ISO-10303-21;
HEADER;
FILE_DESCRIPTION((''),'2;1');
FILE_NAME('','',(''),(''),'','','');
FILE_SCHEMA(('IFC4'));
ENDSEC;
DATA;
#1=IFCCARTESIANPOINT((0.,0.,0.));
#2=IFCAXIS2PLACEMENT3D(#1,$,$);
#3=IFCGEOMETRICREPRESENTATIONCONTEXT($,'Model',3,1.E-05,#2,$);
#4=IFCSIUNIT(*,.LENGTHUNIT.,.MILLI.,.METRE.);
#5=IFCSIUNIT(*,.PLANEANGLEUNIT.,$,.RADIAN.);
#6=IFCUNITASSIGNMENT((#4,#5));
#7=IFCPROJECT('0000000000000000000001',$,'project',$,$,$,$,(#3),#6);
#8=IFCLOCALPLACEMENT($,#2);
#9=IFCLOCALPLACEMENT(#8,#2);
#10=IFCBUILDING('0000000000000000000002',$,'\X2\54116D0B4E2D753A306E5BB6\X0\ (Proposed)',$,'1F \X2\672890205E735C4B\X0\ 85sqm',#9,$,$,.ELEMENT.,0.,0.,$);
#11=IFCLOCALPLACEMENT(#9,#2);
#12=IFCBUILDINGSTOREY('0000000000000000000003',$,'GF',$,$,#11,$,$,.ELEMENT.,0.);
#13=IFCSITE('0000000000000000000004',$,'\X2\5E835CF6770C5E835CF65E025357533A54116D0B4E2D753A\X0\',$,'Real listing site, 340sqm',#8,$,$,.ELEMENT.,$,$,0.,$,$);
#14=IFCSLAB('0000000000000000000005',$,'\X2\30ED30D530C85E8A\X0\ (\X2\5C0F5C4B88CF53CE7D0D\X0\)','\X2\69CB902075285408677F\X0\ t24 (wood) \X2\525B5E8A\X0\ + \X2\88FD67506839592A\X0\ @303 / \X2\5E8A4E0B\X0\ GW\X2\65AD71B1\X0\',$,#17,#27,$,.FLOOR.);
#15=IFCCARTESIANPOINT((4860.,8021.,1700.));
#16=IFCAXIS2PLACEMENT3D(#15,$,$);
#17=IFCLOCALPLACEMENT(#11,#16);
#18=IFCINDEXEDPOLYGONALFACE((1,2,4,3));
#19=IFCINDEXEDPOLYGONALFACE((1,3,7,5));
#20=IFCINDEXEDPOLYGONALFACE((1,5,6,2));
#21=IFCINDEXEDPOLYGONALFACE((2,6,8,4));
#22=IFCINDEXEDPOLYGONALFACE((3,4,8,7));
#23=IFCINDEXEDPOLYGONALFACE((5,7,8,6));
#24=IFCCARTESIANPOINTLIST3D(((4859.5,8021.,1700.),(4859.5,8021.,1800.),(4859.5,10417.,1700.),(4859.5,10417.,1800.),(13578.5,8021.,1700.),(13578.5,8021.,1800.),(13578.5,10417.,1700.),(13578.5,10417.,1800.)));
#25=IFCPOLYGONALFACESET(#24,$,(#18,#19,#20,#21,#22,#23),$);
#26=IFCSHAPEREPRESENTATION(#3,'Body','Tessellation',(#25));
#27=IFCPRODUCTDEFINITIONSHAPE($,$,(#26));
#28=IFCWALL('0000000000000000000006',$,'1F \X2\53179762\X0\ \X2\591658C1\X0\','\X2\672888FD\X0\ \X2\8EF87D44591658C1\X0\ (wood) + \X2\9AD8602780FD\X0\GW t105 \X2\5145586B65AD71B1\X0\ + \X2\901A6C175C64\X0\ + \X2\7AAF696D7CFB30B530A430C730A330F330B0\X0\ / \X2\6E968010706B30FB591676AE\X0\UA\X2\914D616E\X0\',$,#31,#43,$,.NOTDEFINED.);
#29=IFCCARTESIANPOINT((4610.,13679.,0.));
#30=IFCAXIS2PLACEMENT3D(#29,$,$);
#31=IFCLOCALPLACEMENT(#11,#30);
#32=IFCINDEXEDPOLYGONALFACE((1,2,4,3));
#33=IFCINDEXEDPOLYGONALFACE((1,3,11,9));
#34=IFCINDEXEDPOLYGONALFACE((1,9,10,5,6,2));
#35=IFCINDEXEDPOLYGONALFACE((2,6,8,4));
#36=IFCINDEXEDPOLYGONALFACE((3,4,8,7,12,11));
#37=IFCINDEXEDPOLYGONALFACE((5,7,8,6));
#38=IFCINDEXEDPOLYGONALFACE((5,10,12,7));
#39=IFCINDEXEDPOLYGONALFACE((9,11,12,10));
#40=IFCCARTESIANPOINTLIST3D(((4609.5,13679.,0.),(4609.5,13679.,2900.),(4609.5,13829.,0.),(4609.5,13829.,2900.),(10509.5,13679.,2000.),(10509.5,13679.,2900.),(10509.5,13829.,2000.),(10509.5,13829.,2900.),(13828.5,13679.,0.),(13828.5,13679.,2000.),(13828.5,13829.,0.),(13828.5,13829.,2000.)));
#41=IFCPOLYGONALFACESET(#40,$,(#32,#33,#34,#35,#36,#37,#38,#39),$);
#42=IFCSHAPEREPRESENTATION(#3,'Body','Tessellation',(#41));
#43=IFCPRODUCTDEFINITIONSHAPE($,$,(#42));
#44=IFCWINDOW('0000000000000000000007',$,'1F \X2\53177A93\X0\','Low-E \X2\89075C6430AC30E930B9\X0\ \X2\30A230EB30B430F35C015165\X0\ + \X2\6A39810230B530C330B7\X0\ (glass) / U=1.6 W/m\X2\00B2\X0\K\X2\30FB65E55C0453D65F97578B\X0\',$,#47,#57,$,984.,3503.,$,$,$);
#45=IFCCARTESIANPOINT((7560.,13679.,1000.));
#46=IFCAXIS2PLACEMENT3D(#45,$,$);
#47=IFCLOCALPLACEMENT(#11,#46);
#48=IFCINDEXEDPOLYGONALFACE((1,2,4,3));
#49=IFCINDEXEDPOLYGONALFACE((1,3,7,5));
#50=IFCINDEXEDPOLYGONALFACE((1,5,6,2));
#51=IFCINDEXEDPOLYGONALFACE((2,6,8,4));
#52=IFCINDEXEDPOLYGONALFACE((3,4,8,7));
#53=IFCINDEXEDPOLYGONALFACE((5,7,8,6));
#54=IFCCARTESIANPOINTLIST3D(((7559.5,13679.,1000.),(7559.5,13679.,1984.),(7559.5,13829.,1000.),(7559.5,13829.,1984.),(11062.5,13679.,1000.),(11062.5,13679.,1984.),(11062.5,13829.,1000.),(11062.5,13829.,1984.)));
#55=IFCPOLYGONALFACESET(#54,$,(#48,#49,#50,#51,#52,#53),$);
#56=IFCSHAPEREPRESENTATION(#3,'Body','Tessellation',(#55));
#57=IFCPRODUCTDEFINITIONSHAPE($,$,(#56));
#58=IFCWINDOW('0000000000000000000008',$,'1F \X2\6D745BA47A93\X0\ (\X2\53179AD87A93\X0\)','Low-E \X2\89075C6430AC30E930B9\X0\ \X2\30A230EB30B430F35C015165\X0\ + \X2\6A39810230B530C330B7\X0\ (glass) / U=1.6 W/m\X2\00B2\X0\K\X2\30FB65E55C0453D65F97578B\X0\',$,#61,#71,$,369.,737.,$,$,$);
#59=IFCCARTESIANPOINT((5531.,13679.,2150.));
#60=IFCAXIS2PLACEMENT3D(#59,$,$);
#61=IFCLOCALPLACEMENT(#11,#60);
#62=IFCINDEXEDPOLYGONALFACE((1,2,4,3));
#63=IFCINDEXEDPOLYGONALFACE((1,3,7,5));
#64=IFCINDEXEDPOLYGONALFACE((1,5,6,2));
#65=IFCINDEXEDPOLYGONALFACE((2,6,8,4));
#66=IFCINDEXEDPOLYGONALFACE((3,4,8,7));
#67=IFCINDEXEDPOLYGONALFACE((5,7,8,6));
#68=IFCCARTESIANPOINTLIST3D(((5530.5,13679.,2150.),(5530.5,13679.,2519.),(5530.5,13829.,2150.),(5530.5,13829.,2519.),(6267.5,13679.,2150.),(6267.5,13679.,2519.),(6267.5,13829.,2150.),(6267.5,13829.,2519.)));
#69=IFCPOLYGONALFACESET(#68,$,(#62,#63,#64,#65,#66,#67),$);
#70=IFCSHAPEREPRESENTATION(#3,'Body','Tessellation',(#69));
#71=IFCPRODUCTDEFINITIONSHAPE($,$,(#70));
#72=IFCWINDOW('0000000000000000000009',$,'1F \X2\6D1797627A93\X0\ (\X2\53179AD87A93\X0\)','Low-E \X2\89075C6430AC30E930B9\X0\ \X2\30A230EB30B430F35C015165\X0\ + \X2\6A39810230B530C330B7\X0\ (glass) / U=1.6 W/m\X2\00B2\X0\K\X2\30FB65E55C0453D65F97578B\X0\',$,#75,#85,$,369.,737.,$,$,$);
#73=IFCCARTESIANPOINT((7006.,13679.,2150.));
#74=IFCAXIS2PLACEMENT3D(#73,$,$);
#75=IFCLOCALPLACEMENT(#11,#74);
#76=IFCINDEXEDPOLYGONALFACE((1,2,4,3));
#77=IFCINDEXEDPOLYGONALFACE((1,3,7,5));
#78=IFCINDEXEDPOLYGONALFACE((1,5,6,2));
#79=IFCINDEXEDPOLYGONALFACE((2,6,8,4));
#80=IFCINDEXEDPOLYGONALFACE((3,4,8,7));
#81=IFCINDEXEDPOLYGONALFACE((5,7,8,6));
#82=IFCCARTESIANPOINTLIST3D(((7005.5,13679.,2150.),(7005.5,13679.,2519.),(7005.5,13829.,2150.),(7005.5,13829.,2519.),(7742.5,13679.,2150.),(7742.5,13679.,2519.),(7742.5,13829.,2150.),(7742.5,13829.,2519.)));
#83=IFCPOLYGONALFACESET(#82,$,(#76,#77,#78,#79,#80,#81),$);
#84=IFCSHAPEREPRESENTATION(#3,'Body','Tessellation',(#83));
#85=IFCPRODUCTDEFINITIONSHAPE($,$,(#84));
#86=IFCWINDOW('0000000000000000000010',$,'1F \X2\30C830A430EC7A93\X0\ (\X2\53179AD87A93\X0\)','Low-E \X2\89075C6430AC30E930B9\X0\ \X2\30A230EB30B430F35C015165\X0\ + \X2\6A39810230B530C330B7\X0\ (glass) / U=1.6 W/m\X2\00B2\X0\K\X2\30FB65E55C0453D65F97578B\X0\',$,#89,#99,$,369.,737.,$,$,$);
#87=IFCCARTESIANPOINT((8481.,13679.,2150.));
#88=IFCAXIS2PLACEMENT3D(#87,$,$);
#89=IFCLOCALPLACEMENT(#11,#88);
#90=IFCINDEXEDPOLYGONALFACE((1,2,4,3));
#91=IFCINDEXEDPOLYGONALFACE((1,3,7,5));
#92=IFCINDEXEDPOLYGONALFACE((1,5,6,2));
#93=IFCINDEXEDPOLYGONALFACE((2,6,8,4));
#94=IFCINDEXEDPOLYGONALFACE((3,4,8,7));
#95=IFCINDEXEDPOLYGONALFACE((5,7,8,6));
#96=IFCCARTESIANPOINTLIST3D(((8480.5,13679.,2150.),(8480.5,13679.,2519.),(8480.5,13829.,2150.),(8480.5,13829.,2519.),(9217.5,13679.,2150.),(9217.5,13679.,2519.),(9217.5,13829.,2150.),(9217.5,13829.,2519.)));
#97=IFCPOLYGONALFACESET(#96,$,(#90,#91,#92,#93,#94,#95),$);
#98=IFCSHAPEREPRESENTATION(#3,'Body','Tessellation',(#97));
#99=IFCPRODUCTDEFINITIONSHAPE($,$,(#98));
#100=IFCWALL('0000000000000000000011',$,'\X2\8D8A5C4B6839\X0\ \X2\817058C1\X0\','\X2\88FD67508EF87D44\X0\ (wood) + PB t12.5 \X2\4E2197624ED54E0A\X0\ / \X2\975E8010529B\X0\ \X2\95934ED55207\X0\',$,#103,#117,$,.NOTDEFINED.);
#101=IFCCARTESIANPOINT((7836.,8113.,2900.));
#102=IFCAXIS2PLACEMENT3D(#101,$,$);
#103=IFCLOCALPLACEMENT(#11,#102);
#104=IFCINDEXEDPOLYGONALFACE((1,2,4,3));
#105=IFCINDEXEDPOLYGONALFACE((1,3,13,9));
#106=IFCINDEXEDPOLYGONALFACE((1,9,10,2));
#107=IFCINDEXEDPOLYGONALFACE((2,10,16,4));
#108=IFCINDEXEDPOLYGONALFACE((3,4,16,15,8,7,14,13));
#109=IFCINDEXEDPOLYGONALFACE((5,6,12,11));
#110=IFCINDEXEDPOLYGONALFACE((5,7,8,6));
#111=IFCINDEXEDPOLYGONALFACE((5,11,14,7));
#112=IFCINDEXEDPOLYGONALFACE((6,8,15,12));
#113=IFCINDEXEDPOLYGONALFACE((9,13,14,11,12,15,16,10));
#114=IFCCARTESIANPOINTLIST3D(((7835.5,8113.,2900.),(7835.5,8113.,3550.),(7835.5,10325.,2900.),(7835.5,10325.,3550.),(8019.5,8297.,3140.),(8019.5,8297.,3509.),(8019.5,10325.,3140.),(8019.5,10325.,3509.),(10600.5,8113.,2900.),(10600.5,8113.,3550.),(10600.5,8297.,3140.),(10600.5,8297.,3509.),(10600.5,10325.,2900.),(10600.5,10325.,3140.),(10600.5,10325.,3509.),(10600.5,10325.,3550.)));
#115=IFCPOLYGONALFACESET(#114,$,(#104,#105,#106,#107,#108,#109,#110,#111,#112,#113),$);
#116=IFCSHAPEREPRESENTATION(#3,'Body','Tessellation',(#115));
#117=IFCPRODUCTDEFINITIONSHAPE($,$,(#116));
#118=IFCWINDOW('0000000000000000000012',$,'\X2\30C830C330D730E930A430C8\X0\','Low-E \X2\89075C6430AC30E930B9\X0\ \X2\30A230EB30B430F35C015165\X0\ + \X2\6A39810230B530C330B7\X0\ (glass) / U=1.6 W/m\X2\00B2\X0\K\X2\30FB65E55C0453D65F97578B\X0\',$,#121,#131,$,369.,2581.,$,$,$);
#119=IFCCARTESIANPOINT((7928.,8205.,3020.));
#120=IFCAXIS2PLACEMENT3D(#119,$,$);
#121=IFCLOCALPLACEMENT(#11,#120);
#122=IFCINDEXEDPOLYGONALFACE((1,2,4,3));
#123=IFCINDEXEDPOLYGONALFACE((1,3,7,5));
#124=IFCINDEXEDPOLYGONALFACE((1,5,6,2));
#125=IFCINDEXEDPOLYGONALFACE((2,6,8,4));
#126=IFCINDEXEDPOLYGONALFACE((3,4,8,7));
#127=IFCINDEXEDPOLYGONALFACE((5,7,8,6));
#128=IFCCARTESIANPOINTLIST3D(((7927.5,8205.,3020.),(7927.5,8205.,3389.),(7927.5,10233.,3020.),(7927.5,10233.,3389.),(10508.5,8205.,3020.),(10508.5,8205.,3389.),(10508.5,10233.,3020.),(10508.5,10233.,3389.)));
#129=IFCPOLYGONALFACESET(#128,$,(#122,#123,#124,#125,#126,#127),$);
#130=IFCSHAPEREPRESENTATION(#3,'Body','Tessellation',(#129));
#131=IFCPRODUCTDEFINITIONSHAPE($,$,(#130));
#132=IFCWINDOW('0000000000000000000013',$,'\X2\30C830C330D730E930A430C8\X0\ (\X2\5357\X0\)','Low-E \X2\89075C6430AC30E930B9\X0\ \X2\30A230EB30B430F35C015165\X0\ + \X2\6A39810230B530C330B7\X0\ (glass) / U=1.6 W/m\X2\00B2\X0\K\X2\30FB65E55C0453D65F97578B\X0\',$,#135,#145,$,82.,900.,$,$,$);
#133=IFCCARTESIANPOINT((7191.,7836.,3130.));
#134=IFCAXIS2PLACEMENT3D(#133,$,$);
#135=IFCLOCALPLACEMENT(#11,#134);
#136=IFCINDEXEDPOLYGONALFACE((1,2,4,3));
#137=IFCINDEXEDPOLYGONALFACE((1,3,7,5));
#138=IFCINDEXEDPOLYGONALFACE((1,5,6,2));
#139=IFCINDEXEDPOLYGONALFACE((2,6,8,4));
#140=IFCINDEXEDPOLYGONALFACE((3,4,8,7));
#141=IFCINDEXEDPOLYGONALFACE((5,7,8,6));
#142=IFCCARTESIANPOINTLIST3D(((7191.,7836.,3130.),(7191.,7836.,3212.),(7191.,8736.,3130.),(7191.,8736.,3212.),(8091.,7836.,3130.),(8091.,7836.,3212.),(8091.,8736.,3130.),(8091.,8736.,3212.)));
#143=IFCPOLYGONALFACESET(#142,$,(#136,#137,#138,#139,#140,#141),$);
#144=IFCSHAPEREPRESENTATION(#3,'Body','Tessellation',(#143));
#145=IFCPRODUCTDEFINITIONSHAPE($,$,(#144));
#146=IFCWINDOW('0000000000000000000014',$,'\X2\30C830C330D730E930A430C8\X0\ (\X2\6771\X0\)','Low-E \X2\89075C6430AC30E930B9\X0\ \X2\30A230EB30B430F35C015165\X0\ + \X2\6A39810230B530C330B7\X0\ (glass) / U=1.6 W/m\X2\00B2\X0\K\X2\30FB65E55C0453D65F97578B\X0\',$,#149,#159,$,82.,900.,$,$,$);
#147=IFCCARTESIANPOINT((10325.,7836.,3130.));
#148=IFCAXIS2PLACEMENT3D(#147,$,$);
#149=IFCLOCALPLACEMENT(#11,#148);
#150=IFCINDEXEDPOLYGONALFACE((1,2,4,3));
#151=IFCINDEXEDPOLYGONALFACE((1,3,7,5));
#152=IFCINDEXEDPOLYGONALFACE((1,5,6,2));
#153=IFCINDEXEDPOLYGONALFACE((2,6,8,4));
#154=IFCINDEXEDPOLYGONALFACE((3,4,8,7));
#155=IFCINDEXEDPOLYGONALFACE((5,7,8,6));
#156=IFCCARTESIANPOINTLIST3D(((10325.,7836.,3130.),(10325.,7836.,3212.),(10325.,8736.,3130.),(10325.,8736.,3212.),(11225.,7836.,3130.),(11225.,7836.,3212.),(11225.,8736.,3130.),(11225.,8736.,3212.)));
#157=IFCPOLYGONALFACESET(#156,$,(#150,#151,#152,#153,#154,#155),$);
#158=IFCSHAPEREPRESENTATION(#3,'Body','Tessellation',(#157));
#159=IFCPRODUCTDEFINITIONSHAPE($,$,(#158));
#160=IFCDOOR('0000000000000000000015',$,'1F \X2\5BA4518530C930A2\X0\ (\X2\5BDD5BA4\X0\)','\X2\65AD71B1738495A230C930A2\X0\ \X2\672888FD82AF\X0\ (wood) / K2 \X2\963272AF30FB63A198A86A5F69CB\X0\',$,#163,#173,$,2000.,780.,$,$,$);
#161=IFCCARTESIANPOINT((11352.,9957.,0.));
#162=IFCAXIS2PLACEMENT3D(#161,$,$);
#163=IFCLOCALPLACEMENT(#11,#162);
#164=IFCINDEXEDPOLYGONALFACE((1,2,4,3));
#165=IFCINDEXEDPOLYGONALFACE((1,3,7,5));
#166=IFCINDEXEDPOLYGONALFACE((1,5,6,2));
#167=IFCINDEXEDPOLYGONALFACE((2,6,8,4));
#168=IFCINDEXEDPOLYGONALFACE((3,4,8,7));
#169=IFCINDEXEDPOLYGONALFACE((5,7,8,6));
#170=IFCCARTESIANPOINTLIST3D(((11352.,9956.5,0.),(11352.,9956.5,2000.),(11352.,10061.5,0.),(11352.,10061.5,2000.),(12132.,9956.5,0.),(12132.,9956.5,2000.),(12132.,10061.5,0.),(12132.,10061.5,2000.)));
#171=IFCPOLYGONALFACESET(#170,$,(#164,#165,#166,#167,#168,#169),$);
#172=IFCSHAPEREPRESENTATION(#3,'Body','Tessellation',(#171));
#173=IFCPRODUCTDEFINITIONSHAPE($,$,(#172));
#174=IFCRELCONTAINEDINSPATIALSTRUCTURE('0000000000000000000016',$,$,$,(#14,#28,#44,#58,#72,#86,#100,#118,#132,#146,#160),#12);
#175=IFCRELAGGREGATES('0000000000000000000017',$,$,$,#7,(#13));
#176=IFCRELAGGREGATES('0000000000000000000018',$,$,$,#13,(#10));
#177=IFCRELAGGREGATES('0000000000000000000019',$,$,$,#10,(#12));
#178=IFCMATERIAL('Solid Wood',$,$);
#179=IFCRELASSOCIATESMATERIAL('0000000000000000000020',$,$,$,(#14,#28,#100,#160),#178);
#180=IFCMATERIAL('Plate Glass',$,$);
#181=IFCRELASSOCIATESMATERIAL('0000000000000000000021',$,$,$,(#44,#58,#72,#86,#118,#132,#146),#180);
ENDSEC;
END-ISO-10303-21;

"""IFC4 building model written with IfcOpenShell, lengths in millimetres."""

from ifc_helpers import new_model, si_unit, frame, frame_2d, origin, place, context, project, spatial, rectangle, extrude, material, element, fill, save


model = new_model("IFC4")

# Units and contexts
model_context = context("Model", 3, precision=1e-05, world=origin())
ifc_project = project(units=[si_unit("LENGTHUNIT", "METRE", prefix="MILLI"), si_unit("PLANEANGLEUNIT", "RADIAN")], contexts=[model_context])

# Site, building, storey
site_placement = place(None, origin())
site = spatial("IfcSite", under=ifc_project, at=site_placement, Name="広島県広島市南区向洋中町", ObjectType="Real listing site, 340sqm", CompositionType="ELEMENT", RefElevation=0.0)
building_placement = place(site_placement, origin())
building = spatial("IfcBuilding", under=site, at=building_placement, Name="向洋中町の家 (Proposed)", ObjectType="1F 木造平屋 85sqm", CompositionType="ELEMENT", ElevationOfRefHeight=0.0, ElevationOfTerrain=0.0)
storey_placement = place(building_placement, origin())
storey = spatial("IfcBuildingStorey", under=building, at=storey_placement, Name="GF", CompositionType="ELEMENT", Elevation=0.0)

# Slab
ifc_material_1 = material(Name="Solid Wood")
slab_placement = place(storey_placement, frame((4860.0, 8021.0, 1700.0)))
element("IfcSlab", 1, at=slab_placement, inside=storey, material=ifc_material_1, Name="ロフト床 (小屋裏収納)", Description="構造用合板 t24 (wood) 剛床 + 製材根太 @303 / 床下 GW断熱", PredefinedType="FLOOR", context=model_context, shape_type="SweptSolid", body=[
    extrude(rectangle(XDim=8719.0, YDim=2396.0, at=frame_2d((4359.0, 1198.0))), frame((4860.0, 8021.0, 1700.0)), (0.0, 0.0, 1.0), 100.0),
])

# Wall, openings, windows
wall_1_placement = place(storey_placement, frame((4610.0, 13679.0, 0.0)))
wall_1 = element("IfcWall", 2, at=wall_1_placement, inside=storey, material=ifc_material_1, Name="1F 北面 外壁", Description="木製 軸組外壁 (wood) + 高性能GW t105 充填断熱 + 通気層 + 窯業系サイディング / 準耐火・外皮UA配慮", PredefinedType="NOTDEFINED", context=model_context, shape_type="SweptSolid", body=[
    extrude(rectangle(XDim=9219.0, YDim=150.0, at=frame_2d((4609.0, 75.0))), frame((4610.0, 13679.0, 0.0)), (0.0, 0.0, 1.0), 2900.0),
])
opening_1_placement = place(storey_placement, frame((7560.0, 13679.0, 1000.0)))
opening_1 = element("IfcOpeningElement", 3, at=opening_1_placement, cuts=wall_1, PredefinedType="NOTDEFINED", context=model_context, shape_type="SweptSolid", body=[
    extrude(rectangle(XDim=3503.0, YDim=150.0, at=frame_2d((1751.0, 75.0))), frame((7560.0, 13679.0, 1000.0)), (0.0, 0.0, 1.0), 984.0),
])
opening_2_placement = place(storey_placement, frame((5531.0, 13679.0, 2150.0)))
opening_2 = element("IfcOpeningElement", 4, at=opening_2_placement, cuts=wall_1, PredefinedType="NOTDEFINED", context=model_context, shape_type="SweptSolid", body=[
    extrude(rectangle(XDim=737.0, YDim=150.0, at=frame_2d((368.0, 75.0))), frame((5531.0, 13679.0, 2150.0)), (0.0, 0.0, 1.0), 369.0),
])
opening_3_placement = place(storey_placement, frame((7006.0, 13679.0, 2150.0)))
opening_3 = element("IfcOpeningElement", 5, at=opening_3_placement, cuts=wall_1, PredefinedType="NOTDEFINED", context=model_context, shape_type="SweptSolid", body=[
    extrude(rectangle(XDim=737.0, YDim=150.0, at=frame_2d((368.0, 75.0))), frame((7006.0, 13679.0, 2150.0)), (0.0, 0.0, 1.0), 369.0),
])
opening_4_placement = place(storey_placement, frame((8481.0, 13679.0, 2150.0)))
opening_4 = element("IfcOpeningElement", 6, at=opening_4_placement, cuts=wall_1, PredefinedType="NOTDEFINED", context=model_context, shape_type="SweptSolid", body=[
    extrude(rectangle(XDim=737.0, YDim=150.0, at=frame_2d((368.0, 75.0))), frame((8481.0, 13679.0, 2150.0)), (0.0, 0.0, 1.0), 369.0),
])
ifc_material_2 = material(Name="Plate Glass")
window_1_placement = place(storey_placement, frame((7560.0, 13679.0, 1000.0)))
window_1 = element("IfcWindow", 7, at=window_1_placement, inside=storey, material=ifc_material_2, Name="1F 北窓", Description="Low-E 複層ガラス アルゴン封入 + 樹脂サッシ (glass) / U=1.6 W/m²K・日射取得型", OverallHeight=984.0, OverallWidth=3503.0, context=model_context, shape_type="SweptSolid", body=[
    extrude(rectangle(XDim=3503.0, YDim=150.0, at=frame_2d((1751.0, 75.0))), frame((7560.0, 13679.0, 1000.0)), (0.0, 0.0, 1.0), 984.0),
])
fill(opening_1, window_1)
window_2_placement = place(storey_placement, frame((5531.0, 13679.0, 2150.0)))
window_2 = element("IfcWindow", 8, at=window_2_placement, inside=storey, material=ifc_material_2, Name="1F 浴室窓 (北高窓)", Description="Low-E 複層ガラス アルゴン封入 + 樹脂サッシ (glass) / U=1.6 W/m²K・日射取得型", OverallHeight=369.0, OverallWidth=737.0, context=model_context, shape_type="SweptSolid", body=[
    extrude(rectangle(XDim=737.0, YDim=150.0, at=frame_2d((368.0, 75.0))), frame((5531.0, 13679.0, 2150.0)), (0.0, 0.0, 1.0), 369.0),
])
fill(opening_2, window_2)
window_3_placement = place(storey_placement, frame((7006.0, 13679.0, 2150.0)))
window_3 = element("IfcWindow", 9, at=window_3_placement, inside=storey, material=ifc_material_2, Name="1F 洗面窓 (北高窓)", Description="Low-E 複層ガラス アルゴン封入 + 樹脂サッシ (glass) / U=1.6 W/m²K・日射取得型", OverallHeight=369.0, OverallWidth=737.0, context=model_context, shape_type="SweptSolid", body=[
    extrude(rectangle(XDim=737.0, YDim=150.0, at=frame_2d((368.0, 75.0))), frame((7006.0, 13679.0, 2150.0)), (0.0, 0.0, 1.0), 369.0),
])
fill(opening_3, window_3)
window_4_placement = place(storey_placement, frame((8481.0, 13679.0, 2150.0)))
window_4 = element("IfcWindow", 10, at=window_4_placement, inside=storey, material=ifc_material_2, Name="1F トイレ窓 (北高窓)", Description="Low-E 複層ガラス アルゴン封入 + 樹脂サッシ (glass) / U=1.6 W/m²K・日射取得型", OverallHeight=369.0, OverallWidth=737.0, context=model_context, shape_type="SweptSolid", body=[
    extrude(rectangle(XDim=737.0, YDim=150.0, at=frame_2d((368.0, 75.0))), frame((8481.0, 13679.0, 2150.0)), (0.0, 0.0, 1.0), 369.0),
])
fill(opening_4, window_4)

# Wall, openings, windows
wall_2_placement = place(storey_placement, frame((7836.0, 8113.0, 2900.0)))
wall_2 = element("IfcWall", 11, at=wall_2_placement, inside=storey, material=ifc_material_1, Name="越屋根 腰壁", Description="製材軸組 (wood) + PB t12.5 両面仕上 / 非耐力 間仕切", PredefinedType="NOTDEFINED", context=model_context, shape_type="SweptSolid", body=[
    extrude(rectangle(XDim=2765.0, YDim=2212.0, at=frame_2d((1382.0, 1106.0))), frame((7836.0, 8113.0, 2900.0)), (0.0, 0.0, 1.0), 650.0),
])
opening_5_placement = place(storey_placement, frame((7928.0, 8205.0, 3020.0)))
opening_5 = element("IfcOpeningElement", 12, at=opening_5_placement, cuts=wall_2, PredefinedType="NOTDEFINED", context=model_context, shape_type="SweptSolid", body=[
    extrude(rectangle(XDim=2581.0, YDim=2028.0, at=frame_2d((1290.0, 1014.0))), frame((7928.0, 8205.0, 3020.0)), (0.0, 0.0, 1.0), 369.0),
])
opening_6_placement = place(storey_placement, frame((7191.0, 7836.0, 3130.0)))
opening_6 = element("IfcOpeningElement", 13, at=opening_6_placement, cuts=wall_2, PredefinedType="NOTDEFINED", context=model_context, shape_type="SweptSolid", body=[
    extrude(rectangle(XDim=900.0, YDim=900.0, at=frame_2d((450.0, 450.0))), frame((7191.0, 7836.0, 3130.0)), (0.0, 0.0, 1.0), 82.0),
])
opening_7_placement = place(storey_placement, frame((10325.0, 7836.0, 3130.0)))
opening_7 = element("IfcOpeningElement", 14, at=opening_7_placement, cuts=wall_2, PredefinedType="NOTDEFINED", context=model_context, shape_type="SweptSolid", body=[
    extrude(rectangle(XDim=900.0, YDim=900.0, at=frame_2d((450.0, 450.0))), frame((10325.0, 7836.0, 3130.0)), (0.0, 0.0, 1.0), 82.0),
])
window_5_placement = place(storey_placement, frame((7928.0, 8205.0, 3020.0)))
window_5 = element("IfcWindow", 15, at=window_5_placement, inside=storey, material=ifc_material_2, Name="トップライト", Description="Low-E 複層ガラス アルゴン封入 + 樹脂サッシ (glass) / U=1.6 W/m²K・日射取得型", OverallHeight=369.0, OverallWidth=2581.0, context=model_context, shape_type="SweptSolid", body=[
    extrude(rectangle(XDim=2581.0, YDim=2028.0, at=frame_2d((1290.0, 1014.0))), frame((7928.0, 8205.0, 3020.0)), (0.0, 0.0, 1.0), 369.0),
])
fill(opening_5, window_5)
window_6_placement = place(storey_placement, frame((7191.0, 7836.0, 3130.0)))
window_6 = element("IfcWindow", 16, at=window_6_placement, inside=storey, material=ifc_material_2, Name="トップライト (南)", Description="Low-E 複層ガラス アルゴン封入 + 樹脂サッシ (glass) / U=1.6 W/m²K・日射取得型", OverallHeight=82.0, OverallWidth=900.0, context=model_context, shape_type="SweptSolid", body=[
    extrude(rectangle(XDim=900.0, YDim=900.0, at=frame_2d((450.0, 450.0))), frame((7191.0, 7836.0, 3130.0)), (0.0, 0.0, 1.0), 82.0),
])
fill(opening_6, window_6)
window_7_placement = place(storey_placement, frame((10325.0, 7836.0, 3130.0)))
window_7 = element("IfcWindow", 17, at=window_7_placement, inside=storey, material=ifc_material_2, Name="トップライト (東)", Description="Low-E 複層ガラス アルゴン封入 + 樹脂サッシ (glass) / U=1.6 W/m²K・日射取得型", OverallHeight=82.0, OverallWidth=900.0, context=model_context, shape_type="SweptSolid", body=[
    extrude(rectangle(XDim=900.0, YDim=900.0, at=frame_2d((450.0, 450.0))), frame((10325.0, 7836.0, 3130.0)), (0.0, 0.0, 1.0), 82.0),
])
fill(opening_7, window_7)

# Door
door_1_placement = place(storey_placement, frame((11352.0, 9957.0, 0.0)))
element("IfcDoor", 18, at=door_1_placement, inside=storey, material=ifc_material_1, Name="1F 室内ドア (寝室)", Description="断熱玄関ドア 木製芯 (wood) / K2 防犯・採風機構", OverallHeight=2000.0, OverallWidth=780.0, context=model_context, shape_type="SweptSolid", body=[
    extrude(rectangle(XDim=780.0, YDim=105.0, at=frame_2d((390.0, 52.0))), frame((11352.0, 9957.0, 0.0)), (0.0, 0.0, 1.0), 2000.0),
])

save(model, "model.ifc")
